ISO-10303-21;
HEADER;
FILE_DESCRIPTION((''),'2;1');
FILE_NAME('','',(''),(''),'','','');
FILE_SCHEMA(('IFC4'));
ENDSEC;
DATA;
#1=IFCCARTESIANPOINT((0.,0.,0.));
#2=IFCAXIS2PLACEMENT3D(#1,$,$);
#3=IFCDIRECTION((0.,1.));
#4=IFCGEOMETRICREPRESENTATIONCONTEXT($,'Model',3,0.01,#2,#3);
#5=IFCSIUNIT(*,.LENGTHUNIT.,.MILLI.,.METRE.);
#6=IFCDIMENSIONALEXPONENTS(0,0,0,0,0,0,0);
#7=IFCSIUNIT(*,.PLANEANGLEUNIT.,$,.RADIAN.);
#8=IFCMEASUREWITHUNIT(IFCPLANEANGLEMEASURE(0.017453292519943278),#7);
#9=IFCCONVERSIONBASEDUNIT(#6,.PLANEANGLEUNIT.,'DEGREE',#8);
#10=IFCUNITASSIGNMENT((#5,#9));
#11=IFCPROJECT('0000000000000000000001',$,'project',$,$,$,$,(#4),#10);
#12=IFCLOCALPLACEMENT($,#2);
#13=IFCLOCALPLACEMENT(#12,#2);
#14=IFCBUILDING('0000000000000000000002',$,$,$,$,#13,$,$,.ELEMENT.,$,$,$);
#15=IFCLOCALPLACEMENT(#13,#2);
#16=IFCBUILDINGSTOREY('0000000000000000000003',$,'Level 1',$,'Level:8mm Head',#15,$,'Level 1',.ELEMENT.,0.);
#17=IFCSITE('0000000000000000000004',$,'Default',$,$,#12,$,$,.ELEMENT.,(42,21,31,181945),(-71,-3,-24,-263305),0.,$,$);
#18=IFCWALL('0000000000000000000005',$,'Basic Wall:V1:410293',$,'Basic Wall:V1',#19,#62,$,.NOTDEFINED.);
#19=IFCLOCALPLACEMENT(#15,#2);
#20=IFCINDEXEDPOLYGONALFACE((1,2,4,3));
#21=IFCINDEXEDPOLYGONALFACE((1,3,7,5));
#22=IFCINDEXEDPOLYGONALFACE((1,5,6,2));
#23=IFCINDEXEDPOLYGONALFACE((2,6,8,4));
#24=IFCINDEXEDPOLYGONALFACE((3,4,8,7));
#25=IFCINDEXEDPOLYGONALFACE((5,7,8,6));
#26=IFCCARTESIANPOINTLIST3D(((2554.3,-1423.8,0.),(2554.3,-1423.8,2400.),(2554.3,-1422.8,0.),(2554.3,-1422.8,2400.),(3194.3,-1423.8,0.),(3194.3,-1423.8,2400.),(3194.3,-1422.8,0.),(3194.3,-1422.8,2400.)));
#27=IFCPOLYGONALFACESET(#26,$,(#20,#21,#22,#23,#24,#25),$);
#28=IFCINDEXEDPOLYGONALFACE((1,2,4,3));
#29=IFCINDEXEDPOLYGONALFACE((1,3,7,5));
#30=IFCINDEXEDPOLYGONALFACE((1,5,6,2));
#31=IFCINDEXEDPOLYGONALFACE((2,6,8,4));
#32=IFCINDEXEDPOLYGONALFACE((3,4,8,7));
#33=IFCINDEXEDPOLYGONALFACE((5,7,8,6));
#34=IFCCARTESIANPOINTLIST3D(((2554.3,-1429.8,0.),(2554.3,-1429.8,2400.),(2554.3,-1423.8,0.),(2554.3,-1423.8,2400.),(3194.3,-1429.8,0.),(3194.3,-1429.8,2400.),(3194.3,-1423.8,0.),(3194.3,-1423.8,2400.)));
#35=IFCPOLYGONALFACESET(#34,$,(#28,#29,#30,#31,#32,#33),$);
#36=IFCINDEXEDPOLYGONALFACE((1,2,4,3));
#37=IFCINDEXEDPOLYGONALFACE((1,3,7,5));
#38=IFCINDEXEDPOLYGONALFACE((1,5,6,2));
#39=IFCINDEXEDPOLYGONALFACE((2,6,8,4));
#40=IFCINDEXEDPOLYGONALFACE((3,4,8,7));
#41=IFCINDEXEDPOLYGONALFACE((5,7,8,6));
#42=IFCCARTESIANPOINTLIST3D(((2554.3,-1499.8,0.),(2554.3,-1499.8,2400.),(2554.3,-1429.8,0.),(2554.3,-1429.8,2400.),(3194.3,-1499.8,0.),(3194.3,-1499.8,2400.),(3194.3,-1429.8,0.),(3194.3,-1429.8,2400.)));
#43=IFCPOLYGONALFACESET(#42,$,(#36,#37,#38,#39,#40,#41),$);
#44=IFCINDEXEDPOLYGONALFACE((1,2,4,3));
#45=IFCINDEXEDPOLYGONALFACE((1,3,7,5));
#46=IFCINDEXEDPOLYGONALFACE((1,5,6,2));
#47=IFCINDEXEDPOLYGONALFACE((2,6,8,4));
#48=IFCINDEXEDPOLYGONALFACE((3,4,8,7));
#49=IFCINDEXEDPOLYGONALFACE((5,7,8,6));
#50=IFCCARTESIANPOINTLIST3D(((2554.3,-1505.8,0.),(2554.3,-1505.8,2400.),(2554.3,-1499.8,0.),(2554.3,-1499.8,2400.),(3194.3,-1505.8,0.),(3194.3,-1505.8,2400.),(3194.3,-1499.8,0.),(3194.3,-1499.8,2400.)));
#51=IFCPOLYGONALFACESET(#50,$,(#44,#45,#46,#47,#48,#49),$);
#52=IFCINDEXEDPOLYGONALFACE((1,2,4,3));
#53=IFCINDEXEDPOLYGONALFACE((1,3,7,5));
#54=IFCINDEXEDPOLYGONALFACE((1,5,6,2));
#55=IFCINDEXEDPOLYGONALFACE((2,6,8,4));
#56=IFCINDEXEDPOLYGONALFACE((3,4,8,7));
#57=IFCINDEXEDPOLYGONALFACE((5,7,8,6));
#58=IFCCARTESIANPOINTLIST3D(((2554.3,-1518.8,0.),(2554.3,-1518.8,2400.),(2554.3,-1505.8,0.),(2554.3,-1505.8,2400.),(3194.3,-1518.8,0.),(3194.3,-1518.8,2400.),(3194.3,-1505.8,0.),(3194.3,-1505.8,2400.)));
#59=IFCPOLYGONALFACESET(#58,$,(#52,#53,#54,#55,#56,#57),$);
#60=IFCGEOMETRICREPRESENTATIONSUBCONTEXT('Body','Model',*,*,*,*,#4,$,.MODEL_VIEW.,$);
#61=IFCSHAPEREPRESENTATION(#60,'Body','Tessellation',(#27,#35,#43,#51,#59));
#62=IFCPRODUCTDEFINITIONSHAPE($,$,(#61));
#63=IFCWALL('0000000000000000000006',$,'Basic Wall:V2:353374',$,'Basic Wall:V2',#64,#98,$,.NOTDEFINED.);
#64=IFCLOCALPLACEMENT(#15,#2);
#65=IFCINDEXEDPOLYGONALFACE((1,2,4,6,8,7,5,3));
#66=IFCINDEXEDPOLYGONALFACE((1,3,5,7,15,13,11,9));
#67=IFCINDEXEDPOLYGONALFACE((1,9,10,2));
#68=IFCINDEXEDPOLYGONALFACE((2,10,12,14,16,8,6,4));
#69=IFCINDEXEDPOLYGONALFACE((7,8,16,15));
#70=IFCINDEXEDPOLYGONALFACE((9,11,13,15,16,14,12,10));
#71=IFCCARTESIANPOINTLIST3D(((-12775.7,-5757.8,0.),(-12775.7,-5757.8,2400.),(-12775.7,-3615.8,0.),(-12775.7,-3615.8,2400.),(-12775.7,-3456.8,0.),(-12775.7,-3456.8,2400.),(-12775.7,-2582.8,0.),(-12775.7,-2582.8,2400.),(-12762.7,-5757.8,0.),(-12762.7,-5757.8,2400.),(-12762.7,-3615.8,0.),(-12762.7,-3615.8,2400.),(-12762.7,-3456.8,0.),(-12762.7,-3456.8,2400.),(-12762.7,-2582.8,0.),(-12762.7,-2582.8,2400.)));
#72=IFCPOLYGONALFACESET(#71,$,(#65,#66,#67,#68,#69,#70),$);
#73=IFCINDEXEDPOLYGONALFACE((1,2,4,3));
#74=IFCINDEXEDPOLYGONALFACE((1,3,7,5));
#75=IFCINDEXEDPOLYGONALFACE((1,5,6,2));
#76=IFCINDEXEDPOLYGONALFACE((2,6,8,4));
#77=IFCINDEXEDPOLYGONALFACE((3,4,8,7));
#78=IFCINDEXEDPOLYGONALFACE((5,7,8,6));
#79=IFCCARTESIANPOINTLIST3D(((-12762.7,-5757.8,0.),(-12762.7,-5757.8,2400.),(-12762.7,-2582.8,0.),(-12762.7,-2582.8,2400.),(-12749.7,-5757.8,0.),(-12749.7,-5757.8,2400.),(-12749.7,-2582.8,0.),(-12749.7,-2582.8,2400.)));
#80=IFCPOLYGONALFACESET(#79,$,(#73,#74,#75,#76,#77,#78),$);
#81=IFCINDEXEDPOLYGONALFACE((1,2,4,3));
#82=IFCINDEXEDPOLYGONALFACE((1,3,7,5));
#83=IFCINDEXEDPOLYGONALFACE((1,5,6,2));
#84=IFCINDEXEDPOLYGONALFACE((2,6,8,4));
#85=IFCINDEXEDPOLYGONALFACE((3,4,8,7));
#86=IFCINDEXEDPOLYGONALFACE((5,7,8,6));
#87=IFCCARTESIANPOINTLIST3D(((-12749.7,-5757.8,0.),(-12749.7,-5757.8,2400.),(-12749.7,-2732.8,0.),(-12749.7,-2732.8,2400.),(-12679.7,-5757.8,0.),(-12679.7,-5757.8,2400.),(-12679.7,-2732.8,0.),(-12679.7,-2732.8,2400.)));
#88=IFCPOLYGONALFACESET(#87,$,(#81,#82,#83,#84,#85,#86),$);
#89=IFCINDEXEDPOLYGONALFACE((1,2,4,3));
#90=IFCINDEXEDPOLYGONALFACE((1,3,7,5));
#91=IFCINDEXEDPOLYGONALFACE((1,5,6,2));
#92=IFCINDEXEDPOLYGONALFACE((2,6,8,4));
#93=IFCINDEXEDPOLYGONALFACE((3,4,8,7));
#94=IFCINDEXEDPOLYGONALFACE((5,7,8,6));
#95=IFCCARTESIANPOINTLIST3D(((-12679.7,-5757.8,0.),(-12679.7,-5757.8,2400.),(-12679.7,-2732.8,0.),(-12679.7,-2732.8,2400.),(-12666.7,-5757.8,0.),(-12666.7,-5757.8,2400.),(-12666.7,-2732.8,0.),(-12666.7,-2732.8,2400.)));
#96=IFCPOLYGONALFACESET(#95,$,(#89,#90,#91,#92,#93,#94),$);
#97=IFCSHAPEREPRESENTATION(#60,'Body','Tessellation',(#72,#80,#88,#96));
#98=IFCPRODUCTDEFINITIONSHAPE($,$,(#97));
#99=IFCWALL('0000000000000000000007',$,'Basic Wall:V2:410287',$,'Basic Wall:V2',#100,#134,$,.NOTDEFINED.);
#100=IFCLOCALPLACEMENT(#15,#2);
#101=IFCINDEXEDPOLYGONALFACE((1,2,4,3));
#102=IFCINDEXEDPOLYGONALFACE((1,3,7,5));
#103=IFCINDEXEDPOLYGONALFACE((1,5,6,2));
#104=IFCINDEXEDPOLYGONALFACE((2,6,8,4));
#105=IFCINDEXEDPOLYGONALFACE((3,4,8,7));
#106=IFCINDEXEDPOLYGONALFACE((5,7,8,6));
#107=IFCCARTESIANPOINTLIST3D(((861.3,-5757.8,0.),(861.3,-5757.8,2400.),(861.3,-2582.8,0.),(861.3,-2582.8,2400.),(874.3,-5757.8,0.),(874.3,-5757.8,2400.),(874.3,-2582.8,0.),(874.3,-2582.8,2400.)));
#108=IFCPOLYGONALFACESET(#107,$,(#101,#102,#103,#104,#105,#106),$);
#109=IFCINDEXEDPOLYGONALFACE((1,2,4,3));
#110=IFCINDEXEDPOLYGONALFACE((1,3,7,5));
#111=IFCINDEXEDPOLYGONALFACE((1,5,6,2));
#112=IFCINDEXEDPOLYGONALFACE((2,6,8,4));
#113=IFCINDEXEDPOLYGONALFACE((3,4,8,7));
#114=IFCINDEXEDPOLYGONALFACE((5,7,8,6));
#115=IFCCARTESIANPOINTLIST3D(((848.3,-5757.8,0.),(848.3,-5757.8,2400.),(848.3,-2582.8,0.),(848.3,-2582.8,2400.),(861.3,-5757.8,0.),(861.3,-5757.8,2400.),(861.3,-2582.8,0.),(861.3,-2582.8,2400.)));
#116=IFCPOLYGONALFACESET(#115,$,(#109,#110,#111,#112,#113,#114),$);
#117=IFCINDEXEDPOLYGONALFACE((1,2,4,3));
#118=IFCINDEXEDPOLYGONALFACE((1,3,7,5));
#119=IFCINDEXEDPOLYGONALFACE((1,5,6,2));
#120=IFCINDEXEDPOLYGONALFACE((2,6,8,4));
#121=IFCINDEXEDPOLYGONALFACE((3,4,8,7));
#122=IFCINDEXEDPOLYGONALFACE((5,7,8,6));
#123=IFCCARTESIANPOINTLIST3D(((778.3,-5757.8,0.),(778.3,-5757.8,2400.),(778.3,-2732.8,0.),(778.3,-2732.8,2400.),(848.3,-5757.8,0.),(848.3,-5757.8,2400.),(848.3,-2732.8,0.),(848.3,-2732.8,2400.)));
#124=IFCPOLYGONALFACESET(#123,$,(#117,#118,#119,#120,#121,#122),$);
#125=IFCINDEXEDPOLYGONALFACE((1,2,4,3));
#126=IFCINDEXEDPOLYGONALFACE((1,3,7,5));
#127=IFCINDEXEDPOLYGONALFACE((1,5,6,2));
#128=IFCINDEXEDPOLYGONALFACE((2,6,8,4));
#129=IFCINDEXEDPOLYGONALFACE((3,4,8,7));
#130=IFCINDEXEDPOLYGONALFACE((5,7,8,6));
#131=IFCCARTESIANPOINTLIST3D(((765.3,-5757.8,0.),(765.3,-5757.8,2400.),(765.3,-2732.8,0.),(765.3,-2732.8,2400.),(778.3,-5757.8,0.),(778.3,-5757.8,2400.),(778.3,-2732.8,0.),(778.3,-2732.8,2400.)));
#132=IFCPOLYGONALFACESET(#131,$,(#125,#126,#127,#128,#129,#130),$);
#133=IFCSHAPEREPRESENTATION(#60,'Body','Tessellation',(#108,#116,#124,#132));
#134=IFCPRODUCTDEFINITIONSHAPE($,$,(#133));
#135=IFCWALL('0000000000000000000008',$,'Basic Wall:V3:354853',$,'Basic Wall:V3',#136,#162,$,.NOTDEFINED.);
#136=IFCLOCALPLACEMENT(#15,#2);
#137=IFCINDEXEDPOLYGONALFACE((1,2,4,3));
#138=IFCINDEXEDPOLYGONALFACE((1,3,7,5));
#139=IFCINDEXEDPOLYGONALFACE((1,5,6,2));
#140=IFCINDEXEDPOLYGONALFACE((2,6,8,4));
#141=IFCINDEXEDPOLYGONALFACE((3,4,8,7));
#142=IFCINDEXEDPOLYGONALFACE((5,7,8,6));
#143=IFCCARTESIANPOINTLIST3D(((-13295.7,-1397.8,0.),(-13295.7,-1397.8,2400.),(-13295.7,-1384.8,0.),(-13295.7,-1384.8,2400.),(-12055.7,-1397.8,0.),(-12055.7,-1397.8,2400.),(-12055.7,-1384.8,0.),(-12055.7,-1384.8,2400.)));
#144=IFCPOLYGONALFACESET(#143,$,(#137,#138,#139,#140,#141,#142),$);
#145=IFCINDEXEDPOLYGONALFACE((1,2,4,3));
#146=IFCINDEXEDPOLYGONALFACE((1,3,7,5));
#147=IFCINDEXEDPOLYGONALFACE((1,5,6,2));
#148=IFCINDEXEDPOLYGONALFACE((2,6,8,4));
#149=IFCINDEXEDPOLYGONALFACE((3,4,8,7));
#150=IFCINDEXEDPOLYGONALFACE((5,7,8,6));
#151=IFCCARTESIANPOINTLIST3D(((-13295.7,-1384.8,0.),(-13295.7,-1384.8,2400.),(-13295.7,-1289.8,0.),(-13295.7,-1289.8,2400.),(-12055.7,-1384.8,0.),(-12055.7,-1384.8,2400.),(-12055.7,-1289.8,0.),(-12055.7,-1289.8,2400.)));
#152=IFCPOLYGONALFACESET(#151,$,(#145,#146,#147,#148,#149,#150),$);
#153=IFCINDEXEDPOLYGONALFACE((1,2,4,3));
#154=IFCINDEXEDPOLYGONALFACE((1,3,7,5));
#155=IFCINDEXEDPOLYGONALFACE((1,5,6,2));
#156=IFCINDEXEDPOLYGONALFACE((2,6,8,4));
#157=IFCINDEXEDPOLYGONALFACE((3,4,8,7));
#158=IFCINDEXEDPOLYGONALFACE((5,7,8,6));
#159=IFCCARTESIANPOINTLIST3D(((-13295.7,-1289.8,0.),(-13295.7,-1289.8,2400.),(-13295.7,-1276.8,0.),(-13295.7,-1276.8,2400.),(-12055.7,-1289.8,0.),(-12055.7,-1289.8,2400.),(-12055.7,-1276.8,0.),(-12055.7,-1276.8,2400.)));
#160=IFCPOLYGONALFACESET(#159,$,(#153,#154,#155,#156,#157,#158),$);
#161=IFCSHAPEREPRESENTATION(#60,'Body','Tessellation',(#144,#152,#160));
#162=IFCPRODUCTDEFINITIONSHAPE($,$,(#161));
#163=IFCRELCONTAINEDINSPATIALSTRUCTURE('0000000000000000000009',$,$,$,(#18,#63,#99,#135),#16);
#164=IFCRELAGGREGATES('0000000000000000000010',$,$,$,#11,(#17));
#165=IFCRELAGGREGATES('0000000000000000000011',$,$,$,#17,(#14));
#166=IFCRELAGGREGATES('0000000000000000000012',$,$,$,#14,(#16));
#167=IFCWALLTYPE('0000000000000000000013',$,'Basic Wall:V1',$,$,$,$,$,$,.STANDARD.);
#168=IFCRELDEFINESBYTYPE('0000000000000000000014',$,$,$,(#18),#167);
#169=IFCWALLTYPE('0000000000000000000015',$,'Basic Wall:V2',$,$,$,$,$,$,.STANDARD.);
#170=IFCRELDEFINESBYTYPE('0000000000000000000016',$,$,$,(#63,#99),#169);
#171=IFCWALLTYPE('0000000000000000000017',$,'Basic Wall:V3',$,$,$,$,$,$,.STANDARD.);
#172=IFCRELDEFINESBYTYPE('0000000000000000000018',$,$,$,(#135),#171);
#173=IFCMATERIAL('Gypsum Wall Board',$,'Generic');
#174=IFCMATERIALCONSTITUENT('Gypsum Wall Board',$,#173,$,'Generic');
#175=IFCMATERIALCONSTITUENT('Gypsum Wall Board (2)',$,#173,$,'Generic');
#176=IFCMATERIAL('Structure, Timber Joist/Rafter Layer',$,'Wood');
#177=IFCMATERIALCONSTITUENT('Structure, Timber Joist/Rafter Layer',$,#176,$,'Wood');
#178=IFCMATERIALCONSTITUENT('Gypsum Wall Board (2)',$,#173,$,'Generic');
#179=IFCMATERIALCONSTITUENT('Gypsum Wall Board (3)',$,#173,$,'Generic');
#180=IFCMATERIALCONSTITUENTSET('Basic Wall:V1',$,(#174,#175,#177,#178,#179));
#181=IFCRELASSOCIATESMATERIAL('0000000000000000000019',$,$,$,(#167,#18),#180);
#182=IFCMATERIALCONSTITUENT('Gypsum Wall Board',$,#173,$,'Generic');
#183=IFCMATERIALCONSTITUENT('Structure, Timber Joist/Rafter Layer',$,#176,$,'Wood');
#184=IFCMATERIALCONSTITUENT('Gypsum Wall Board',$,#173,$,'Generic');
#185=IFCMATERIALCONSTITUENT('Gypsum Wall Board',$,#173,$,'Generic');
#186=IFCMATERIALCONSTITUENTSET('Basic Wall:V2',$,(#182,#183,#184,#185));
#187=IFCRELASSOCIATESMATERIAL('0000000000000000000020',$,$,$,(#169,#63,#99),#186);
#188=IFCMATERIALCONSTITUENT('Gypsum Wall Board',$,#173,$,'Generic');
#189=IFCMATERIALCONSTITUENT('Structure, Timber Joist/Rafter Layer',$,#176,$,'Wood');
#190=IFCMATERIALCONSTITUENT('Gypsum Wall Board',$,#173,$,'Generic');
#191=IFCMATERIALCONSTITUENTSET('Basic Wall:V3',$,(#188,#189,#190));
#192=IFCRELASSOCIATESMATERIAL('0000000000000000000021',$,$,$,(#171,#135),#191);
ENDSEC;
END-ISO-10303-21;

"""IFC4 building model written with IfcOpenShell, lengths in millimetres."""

from ifc_helpers import new_model, entity, si_unit, converted_unit, direction, frame, origin, place, context, subcontext, project, spatial, indexed_curve, outline, extrude, material, constituent, constituent_set, type_object, element, save


model = new_model("IFC4")

# Units and contexts
model_context = context("Model", 3, precision=0.01, world=origin(), true_north=direction((0.0, 1.0)))
body_context = subcontext(model_context, "Body", "Model", "MODEL_VIEW")
ifc_project = project(units=[si_unit("LENGTHUNIT", "METRE", prefix="MILLI"), converted_unit("PLANEANGLEUNIT", "DEGREE", entity("IfcPlaneAngleMeasure", 0.017453292519943278), si_unit("PLANEANGLEUNIT", "RADIAN"), dimensions=[0, 0, 0, 0, 0, 0, 0])], contexts=[model_context])

# Site, building, storey
site_placement = place(None, origin())
site = spatial("IfcSite", under=ifc_project, at=site_placement, Name="Default", CompositionType="ELEMENT", RefLatitude=(42, 21, 31, 181945), RefLongitude=(-71, -3, -24, -263305), RefElevation=0.0)
building_placement = place(site_placement, origin())
building = spatial("IfcBuilding", under=site, at=building_placement, CompositionType="ELEMENT")
storey_placement = place(building_placement, origin())
storey = spatial("IfcBuildingStorey", under=building, at=storey_placement, Name="Level 1", ObjectType="Level:8mm Head", LongName="Level 1", CompositionType="ELEMENT", Elevation=0.0)

# Walls
ifc_material_1 = material(Name="Gypsum Wall Board", Category="Generic")
ifc_constituent_1 = constituent(ifc_material_1, Name="Gypsum Wall Board", Category="Generic")
ifc_constituent_2 = constituent(ifc_material_1, Name="Gypsum Wall Board (2)", Category="Generic")
ifc_material_2 = material(Name="Structure, Timber Joist/Rafter Layer", Category="Wood")
ifc_constituent_3 = constituent(ifc_material_2, Name="Structure, Timber Joist/Rafter Layer", Category="Wood")
ifc_constituent_4 = constituent(ifc_material_1, Name="Gypsum Wall Board (2)", Category="Generic")
ifc_constituent_5 = constituent(ifc_material_1, Name="Gypsum Wall Board (3)", Category="Generic")
ifc_constituent_set_1 = constituent_set(constituents=[ifc_constituent_1, ifc_constituent_2, ifc_constituent_3, ifc_constituent_4, ifc_constituent_5], Name="Basic Wall:V1")
wall_type_1 = type_object("IfcWallType", Name="Basic Wall:V1", PredefinedType="STANDARD", material=ifc_constituent_set_1)
wall_1_placement = place(storey_placement, frame((2554.3, -1470.8, 0.0)))
element("IfcWall", 1, at=wall_1_placement, inside=storey, type_object=wall_type_1, material=ifc_constituent_set_1, Name="Basic Wall:V1:410293", ObjectType="Basic Wall:V1", PredefinedType="NOTDEFINED", context=body_context, shape_type="SweptSolid", body=[
    extrude(outline(indexed_curve([(-0.5, -320.0), (0.5, -320.0), (0.5, 320.0), (-0.5, 320.0), (-0.5, -320.0)], self_intersect=False)), frame((320.0, 47.5, 0.0), z_axis=(0.0, 0.0, 1.0), x_axis=(0.0, -1.0, 0.0)), (0.0, 0.0, 1.0), 2400.0),
    extrude(outline(indexed_curve([(-320.0, -3.0), (320.0, -3.0), (320.0, 3.0), (-320.0, 3.0), (-320.0, -3.0)], self_intersect=False)), frame((320.0, 44.0, 0.0)), (0.0, 0.0, 1.0), 2400.0),
    extrude(outline(indexed_curve([(-320.0, -35.0), (320.0, -35.0), (320.0, 35.0), (-320.0, 35.0), (-320.0, -35.0)], self_intersect=False)), frame((320.0, 6.0, 0.0)), (0.0, 0.0, 1.0), 2400.0),
    extrude(outline(indexed_curve([(-320.0, -3.0), (320.0, -3.0), (320.0, 3.0), (-320.0, 3.0), (-320.0, -3.0)], self_intersect=False)), frame((320.0, -32.0, 0.0)), (0.0, 0.0, 1.0), 2400.0),
    extrude(outline(indexed_curve([(-6.5, -320.0), (6.5, -320.0), (6.5, 320.0), (-6.5, 320.0), (-6.5, -320.0)], self_intersect=False)), frame((320.0, -41.5, 0.0), z_axis=(0.0, 0.0, 1.0), x_axis=(0.0, 1.0, 0.0)), (0.0, 0.0, 1.0), 2400.0),
])
ifc_constituent_6 = constituent(ifc_material_1, Name="Gypsum Wall Board", Category="Generic")
ifc_constituent_7 = constituent(ifc_material_2, Name="Structure, Timber Joist/Rafter Layer", Category="Wood")
ifc_constituent_8 = constituent(ifc_material_1, Name="Gypsum Wall Board", Category="Generic")
ifc_constituent_9 = constituent(ifc_material_1, Name="Gypsum Wall Board", Category="Generic")
ifc_constituent_set_2 = constituent_set(constituents=[ifc_constituent_6, ifc_constituent_7, ifc_constituent_8, ifc_constituent_9], Name="Basic Wall:V2")
wall_type_2 = type_object("IfcWallType", Name="Basic Wall:V2", PredefinedType="STANDARD", material=ifc_constituent_set_2)
wall_2_placement = place(storey_placement, frame((-12721.2, -2732.8, 0.0), z_axis=(0.0, 0.0, 1.0), x_axis=(0.0, -1.0, 0.0)))
element("IfcWall", 2, at=wall_2_placement, inside=storey, type_object=wall_type_2, material=ifc_constituent_set_2, Name="Basic Wall:V2:353374", ObjectType="Basic Wall:V2", PredefinedType="NOTDEFINED", context=body_context, shape_type="SweptSolid", body=[
    extrude(outline(indexed_curve([(-1200.0, -1270.5), (1200.0, -1270.5), (1200.0, -396.5), (1200.0, -237.5), (1200.0, 1904.5), (-1200.0, 1904.5), (-1200.0, -237.5), (-1200.0, -396.5), (-1200.0, -1270.5)], self_intersect=False)), frame((1120.5, -54.5, 1200.0), z_axis=(0.0, 1.0, 0.0), x_axis=(0.0, 0.0, 1.0)), (0.0, 0.0, 1.0), 13.0),
    extrude(outline(indexed_curve([(-1200.0, -1587.5), (1200.0, -1587.5), (1200.0, 1587.5), (-1200.0, 1587.5), (-1200.0, -1587.5)], self_intersect=False)), frame((1437.5, -41.5, 1200.0), z_axis=(0.0, 1.0, 0.0), x_axis=(0.0, 0.0, 1.0)), (0.0, 0.0, 1.0), 13.0),
    extrude(outline(indexed_curve([(-1200.0, -1512.5), (1200.0, -1512.5), (1200.0, 1512.5), (-1200.0, 1512.5), (-1200.0, -1512.5)], self_intersect=False)), frame((1512.5, -28.5, 1200.0), z_axis=(0.0, 1.0, 0.0), x_axis=(0.0, 0.0, 1.0)), (0.0, 0.0, 1.0), 70.0),
    extrude(outline(indexed_curve([(-1200.0, -1512.5), (1200.0, -1512.5), (1200.0, 1512.5), (-1200.0, 1512.5), (-1200.0, -1512.5)], self_intersect=False)), frame((1512.5, 41.5, 1200.0), z_axis=(0.0, 1.0, 0.0), x_axis=(0.0, 0.0, 1.0)), (0.0, 0.0, 1.0), 13.0),
])
wall_3_placement = place(storey_placement, frame((819.8, -2732.8, 0.0), z_axis=(0.0, 0.0, 1.0), x_axis=(0.0, -1.0, 0.0)))
element("IfcWall", 3, at=wall_3_placement, inside=storey, type_object=wall_type_2, material=ifc_constituent_set_2, Name="Basic Wall:V2:410287", ObjectType="Basic Wall:V2", PredefinedType="NOTDEFINED", context=body_context, shape_type="SweptSolid", body=[
    extrude(outline(indexed_curve([(-1200.0, -1587.5), (1200.0, -1587.5), (1200.0, 1587.5), (-1200.0, 1587.5), (-1200.0, -1587.5)], self_intersect=False)), frame((1437.5, 41.5, 1200.0), z_axis=(0.0, 1.0, 0.0), x_axis=(0.0, 0.0, 1.0)), (0.0, 0.0, 1.0), 13.0),
    extrude(outline(indexed_curve([(-1200.0, -1587.5), (1200.0, -1587.5), (1200.0, 1587.5), (-1200.0, 1587.5), (-1200.0, -1587.5)], self_intersect=False)), frame((1437.5, 28.5, 1200.0), z_axis=(0.0, 1.0, 0.0), x_axis=(0.0, 0.0, 1.0)), (0.0, 0.0, 1.0), 13.0),
    extrude(outline(indexed_curve([(-1200.0, -1512.5), (1200.0, -1512.5), (1200.0, 1512.5), (-1200.0, 1512.5), (-1200.0, -1512.5)], self_intersect=False)), frame((1512.5, -41.5, 1200.0), z_axis=(0.0, 1.0, 0.0), x_axis=(0.0, 0.0, 1.0)), (0.0, 0.0, 1.0), 70.0),
    extrude(outline(indexed_curve([(-1200.0, -1512.5), (1200.0, -1512.5), (1200.0, 1512.5), (-1200.0, 1512.5), (-1200.0, -1512.5)], self_intersect=False)), frame((1512.5, -54.5, 1200.0), z_axis=(0.0, 1.0, 0.0), x_axis=(0.0, 0.0, 1.0)), (0.0, 0.0, 1.0), 13.0),
])

# Wall
ifc_constituent_10 = constituent(ifc_material_1, Name="Gypsum Wall Board", Category="Generic")
ifc_constituent_11 = constituent(ifc_material_2, Name="Structure, Timber Joist/Rafter Layer", Category="Wood")
ifc_constituent_12 = constituent(ifc_material_1, Name="Gypsum Wall Board", Category="Generic")
ifc_constituent_set_3 = constituent_set(constituents=[ifc_constituent_10, ifc_constituent_11, ifc_constituent_12], Name="Basic Wall:V3")
wall_type_3 = type_object("IfcWallType", Name="Basic Wall:V3", PredefinedType="STANDARD", material=ifc_constituent_set_3)
wall_4_placement = place(storey_placement, frame((-12055.7, -1337.3, 0.0), z_axis=(0.0, 0.0, 1.0), x_axis=(-1.0, 0.0, 0.0)))
element("IfcWall", 4, at=wall_4_placement, inside=storey, type_object=wall_type_3, material=ifc_constituent_set_3, Name="Basic Wall:V3:354853", ObjectType="Basic Wall:V3", PredefinedType="NOTDEFINED", context=body_context, shape_type="SweptSolid", body=[
    extrude(outline(indexed_curve([(-6.5, -620.0), (6.5, -620.0), (6.5, 620.0), (-6.5, 620.0), (-6.5, -620.0)], self_intersect=False)), frame((620.0, 54.0, 0.0), z_axis=(0.0, 0.0, 1.0), x_axis=(0.0, -1.0, 0.0)), (0.0, 0.0, 1.0), 2400.0),
    extrude(outline(indexed_curve([(-620.0, -47.5), (620.0, -47.5), (620.0, 47.5), (-620.0, 47.5), (-620.0, -47.5)], self_intersect=False)), frame((620.0, 0.0, 0.0)), (0.0, 0.0, 1.0), 2400.0),
    extrude(outline(indexed_curve([(-6.5, -620.0), (6.5, -620.0), (6.5, 620.0), (-6.5, 620.0), (-6.5, -620.0)], self_intersect=False)), frame((620.0, -54.0, 0.0), z_axis=(0.0, 0.0, 1.0), x_axis=(0.0, 1.0, 0.0)), (0.0, 0.0, 1.0), 2400.0),
])

save(model, "model.ifc")
